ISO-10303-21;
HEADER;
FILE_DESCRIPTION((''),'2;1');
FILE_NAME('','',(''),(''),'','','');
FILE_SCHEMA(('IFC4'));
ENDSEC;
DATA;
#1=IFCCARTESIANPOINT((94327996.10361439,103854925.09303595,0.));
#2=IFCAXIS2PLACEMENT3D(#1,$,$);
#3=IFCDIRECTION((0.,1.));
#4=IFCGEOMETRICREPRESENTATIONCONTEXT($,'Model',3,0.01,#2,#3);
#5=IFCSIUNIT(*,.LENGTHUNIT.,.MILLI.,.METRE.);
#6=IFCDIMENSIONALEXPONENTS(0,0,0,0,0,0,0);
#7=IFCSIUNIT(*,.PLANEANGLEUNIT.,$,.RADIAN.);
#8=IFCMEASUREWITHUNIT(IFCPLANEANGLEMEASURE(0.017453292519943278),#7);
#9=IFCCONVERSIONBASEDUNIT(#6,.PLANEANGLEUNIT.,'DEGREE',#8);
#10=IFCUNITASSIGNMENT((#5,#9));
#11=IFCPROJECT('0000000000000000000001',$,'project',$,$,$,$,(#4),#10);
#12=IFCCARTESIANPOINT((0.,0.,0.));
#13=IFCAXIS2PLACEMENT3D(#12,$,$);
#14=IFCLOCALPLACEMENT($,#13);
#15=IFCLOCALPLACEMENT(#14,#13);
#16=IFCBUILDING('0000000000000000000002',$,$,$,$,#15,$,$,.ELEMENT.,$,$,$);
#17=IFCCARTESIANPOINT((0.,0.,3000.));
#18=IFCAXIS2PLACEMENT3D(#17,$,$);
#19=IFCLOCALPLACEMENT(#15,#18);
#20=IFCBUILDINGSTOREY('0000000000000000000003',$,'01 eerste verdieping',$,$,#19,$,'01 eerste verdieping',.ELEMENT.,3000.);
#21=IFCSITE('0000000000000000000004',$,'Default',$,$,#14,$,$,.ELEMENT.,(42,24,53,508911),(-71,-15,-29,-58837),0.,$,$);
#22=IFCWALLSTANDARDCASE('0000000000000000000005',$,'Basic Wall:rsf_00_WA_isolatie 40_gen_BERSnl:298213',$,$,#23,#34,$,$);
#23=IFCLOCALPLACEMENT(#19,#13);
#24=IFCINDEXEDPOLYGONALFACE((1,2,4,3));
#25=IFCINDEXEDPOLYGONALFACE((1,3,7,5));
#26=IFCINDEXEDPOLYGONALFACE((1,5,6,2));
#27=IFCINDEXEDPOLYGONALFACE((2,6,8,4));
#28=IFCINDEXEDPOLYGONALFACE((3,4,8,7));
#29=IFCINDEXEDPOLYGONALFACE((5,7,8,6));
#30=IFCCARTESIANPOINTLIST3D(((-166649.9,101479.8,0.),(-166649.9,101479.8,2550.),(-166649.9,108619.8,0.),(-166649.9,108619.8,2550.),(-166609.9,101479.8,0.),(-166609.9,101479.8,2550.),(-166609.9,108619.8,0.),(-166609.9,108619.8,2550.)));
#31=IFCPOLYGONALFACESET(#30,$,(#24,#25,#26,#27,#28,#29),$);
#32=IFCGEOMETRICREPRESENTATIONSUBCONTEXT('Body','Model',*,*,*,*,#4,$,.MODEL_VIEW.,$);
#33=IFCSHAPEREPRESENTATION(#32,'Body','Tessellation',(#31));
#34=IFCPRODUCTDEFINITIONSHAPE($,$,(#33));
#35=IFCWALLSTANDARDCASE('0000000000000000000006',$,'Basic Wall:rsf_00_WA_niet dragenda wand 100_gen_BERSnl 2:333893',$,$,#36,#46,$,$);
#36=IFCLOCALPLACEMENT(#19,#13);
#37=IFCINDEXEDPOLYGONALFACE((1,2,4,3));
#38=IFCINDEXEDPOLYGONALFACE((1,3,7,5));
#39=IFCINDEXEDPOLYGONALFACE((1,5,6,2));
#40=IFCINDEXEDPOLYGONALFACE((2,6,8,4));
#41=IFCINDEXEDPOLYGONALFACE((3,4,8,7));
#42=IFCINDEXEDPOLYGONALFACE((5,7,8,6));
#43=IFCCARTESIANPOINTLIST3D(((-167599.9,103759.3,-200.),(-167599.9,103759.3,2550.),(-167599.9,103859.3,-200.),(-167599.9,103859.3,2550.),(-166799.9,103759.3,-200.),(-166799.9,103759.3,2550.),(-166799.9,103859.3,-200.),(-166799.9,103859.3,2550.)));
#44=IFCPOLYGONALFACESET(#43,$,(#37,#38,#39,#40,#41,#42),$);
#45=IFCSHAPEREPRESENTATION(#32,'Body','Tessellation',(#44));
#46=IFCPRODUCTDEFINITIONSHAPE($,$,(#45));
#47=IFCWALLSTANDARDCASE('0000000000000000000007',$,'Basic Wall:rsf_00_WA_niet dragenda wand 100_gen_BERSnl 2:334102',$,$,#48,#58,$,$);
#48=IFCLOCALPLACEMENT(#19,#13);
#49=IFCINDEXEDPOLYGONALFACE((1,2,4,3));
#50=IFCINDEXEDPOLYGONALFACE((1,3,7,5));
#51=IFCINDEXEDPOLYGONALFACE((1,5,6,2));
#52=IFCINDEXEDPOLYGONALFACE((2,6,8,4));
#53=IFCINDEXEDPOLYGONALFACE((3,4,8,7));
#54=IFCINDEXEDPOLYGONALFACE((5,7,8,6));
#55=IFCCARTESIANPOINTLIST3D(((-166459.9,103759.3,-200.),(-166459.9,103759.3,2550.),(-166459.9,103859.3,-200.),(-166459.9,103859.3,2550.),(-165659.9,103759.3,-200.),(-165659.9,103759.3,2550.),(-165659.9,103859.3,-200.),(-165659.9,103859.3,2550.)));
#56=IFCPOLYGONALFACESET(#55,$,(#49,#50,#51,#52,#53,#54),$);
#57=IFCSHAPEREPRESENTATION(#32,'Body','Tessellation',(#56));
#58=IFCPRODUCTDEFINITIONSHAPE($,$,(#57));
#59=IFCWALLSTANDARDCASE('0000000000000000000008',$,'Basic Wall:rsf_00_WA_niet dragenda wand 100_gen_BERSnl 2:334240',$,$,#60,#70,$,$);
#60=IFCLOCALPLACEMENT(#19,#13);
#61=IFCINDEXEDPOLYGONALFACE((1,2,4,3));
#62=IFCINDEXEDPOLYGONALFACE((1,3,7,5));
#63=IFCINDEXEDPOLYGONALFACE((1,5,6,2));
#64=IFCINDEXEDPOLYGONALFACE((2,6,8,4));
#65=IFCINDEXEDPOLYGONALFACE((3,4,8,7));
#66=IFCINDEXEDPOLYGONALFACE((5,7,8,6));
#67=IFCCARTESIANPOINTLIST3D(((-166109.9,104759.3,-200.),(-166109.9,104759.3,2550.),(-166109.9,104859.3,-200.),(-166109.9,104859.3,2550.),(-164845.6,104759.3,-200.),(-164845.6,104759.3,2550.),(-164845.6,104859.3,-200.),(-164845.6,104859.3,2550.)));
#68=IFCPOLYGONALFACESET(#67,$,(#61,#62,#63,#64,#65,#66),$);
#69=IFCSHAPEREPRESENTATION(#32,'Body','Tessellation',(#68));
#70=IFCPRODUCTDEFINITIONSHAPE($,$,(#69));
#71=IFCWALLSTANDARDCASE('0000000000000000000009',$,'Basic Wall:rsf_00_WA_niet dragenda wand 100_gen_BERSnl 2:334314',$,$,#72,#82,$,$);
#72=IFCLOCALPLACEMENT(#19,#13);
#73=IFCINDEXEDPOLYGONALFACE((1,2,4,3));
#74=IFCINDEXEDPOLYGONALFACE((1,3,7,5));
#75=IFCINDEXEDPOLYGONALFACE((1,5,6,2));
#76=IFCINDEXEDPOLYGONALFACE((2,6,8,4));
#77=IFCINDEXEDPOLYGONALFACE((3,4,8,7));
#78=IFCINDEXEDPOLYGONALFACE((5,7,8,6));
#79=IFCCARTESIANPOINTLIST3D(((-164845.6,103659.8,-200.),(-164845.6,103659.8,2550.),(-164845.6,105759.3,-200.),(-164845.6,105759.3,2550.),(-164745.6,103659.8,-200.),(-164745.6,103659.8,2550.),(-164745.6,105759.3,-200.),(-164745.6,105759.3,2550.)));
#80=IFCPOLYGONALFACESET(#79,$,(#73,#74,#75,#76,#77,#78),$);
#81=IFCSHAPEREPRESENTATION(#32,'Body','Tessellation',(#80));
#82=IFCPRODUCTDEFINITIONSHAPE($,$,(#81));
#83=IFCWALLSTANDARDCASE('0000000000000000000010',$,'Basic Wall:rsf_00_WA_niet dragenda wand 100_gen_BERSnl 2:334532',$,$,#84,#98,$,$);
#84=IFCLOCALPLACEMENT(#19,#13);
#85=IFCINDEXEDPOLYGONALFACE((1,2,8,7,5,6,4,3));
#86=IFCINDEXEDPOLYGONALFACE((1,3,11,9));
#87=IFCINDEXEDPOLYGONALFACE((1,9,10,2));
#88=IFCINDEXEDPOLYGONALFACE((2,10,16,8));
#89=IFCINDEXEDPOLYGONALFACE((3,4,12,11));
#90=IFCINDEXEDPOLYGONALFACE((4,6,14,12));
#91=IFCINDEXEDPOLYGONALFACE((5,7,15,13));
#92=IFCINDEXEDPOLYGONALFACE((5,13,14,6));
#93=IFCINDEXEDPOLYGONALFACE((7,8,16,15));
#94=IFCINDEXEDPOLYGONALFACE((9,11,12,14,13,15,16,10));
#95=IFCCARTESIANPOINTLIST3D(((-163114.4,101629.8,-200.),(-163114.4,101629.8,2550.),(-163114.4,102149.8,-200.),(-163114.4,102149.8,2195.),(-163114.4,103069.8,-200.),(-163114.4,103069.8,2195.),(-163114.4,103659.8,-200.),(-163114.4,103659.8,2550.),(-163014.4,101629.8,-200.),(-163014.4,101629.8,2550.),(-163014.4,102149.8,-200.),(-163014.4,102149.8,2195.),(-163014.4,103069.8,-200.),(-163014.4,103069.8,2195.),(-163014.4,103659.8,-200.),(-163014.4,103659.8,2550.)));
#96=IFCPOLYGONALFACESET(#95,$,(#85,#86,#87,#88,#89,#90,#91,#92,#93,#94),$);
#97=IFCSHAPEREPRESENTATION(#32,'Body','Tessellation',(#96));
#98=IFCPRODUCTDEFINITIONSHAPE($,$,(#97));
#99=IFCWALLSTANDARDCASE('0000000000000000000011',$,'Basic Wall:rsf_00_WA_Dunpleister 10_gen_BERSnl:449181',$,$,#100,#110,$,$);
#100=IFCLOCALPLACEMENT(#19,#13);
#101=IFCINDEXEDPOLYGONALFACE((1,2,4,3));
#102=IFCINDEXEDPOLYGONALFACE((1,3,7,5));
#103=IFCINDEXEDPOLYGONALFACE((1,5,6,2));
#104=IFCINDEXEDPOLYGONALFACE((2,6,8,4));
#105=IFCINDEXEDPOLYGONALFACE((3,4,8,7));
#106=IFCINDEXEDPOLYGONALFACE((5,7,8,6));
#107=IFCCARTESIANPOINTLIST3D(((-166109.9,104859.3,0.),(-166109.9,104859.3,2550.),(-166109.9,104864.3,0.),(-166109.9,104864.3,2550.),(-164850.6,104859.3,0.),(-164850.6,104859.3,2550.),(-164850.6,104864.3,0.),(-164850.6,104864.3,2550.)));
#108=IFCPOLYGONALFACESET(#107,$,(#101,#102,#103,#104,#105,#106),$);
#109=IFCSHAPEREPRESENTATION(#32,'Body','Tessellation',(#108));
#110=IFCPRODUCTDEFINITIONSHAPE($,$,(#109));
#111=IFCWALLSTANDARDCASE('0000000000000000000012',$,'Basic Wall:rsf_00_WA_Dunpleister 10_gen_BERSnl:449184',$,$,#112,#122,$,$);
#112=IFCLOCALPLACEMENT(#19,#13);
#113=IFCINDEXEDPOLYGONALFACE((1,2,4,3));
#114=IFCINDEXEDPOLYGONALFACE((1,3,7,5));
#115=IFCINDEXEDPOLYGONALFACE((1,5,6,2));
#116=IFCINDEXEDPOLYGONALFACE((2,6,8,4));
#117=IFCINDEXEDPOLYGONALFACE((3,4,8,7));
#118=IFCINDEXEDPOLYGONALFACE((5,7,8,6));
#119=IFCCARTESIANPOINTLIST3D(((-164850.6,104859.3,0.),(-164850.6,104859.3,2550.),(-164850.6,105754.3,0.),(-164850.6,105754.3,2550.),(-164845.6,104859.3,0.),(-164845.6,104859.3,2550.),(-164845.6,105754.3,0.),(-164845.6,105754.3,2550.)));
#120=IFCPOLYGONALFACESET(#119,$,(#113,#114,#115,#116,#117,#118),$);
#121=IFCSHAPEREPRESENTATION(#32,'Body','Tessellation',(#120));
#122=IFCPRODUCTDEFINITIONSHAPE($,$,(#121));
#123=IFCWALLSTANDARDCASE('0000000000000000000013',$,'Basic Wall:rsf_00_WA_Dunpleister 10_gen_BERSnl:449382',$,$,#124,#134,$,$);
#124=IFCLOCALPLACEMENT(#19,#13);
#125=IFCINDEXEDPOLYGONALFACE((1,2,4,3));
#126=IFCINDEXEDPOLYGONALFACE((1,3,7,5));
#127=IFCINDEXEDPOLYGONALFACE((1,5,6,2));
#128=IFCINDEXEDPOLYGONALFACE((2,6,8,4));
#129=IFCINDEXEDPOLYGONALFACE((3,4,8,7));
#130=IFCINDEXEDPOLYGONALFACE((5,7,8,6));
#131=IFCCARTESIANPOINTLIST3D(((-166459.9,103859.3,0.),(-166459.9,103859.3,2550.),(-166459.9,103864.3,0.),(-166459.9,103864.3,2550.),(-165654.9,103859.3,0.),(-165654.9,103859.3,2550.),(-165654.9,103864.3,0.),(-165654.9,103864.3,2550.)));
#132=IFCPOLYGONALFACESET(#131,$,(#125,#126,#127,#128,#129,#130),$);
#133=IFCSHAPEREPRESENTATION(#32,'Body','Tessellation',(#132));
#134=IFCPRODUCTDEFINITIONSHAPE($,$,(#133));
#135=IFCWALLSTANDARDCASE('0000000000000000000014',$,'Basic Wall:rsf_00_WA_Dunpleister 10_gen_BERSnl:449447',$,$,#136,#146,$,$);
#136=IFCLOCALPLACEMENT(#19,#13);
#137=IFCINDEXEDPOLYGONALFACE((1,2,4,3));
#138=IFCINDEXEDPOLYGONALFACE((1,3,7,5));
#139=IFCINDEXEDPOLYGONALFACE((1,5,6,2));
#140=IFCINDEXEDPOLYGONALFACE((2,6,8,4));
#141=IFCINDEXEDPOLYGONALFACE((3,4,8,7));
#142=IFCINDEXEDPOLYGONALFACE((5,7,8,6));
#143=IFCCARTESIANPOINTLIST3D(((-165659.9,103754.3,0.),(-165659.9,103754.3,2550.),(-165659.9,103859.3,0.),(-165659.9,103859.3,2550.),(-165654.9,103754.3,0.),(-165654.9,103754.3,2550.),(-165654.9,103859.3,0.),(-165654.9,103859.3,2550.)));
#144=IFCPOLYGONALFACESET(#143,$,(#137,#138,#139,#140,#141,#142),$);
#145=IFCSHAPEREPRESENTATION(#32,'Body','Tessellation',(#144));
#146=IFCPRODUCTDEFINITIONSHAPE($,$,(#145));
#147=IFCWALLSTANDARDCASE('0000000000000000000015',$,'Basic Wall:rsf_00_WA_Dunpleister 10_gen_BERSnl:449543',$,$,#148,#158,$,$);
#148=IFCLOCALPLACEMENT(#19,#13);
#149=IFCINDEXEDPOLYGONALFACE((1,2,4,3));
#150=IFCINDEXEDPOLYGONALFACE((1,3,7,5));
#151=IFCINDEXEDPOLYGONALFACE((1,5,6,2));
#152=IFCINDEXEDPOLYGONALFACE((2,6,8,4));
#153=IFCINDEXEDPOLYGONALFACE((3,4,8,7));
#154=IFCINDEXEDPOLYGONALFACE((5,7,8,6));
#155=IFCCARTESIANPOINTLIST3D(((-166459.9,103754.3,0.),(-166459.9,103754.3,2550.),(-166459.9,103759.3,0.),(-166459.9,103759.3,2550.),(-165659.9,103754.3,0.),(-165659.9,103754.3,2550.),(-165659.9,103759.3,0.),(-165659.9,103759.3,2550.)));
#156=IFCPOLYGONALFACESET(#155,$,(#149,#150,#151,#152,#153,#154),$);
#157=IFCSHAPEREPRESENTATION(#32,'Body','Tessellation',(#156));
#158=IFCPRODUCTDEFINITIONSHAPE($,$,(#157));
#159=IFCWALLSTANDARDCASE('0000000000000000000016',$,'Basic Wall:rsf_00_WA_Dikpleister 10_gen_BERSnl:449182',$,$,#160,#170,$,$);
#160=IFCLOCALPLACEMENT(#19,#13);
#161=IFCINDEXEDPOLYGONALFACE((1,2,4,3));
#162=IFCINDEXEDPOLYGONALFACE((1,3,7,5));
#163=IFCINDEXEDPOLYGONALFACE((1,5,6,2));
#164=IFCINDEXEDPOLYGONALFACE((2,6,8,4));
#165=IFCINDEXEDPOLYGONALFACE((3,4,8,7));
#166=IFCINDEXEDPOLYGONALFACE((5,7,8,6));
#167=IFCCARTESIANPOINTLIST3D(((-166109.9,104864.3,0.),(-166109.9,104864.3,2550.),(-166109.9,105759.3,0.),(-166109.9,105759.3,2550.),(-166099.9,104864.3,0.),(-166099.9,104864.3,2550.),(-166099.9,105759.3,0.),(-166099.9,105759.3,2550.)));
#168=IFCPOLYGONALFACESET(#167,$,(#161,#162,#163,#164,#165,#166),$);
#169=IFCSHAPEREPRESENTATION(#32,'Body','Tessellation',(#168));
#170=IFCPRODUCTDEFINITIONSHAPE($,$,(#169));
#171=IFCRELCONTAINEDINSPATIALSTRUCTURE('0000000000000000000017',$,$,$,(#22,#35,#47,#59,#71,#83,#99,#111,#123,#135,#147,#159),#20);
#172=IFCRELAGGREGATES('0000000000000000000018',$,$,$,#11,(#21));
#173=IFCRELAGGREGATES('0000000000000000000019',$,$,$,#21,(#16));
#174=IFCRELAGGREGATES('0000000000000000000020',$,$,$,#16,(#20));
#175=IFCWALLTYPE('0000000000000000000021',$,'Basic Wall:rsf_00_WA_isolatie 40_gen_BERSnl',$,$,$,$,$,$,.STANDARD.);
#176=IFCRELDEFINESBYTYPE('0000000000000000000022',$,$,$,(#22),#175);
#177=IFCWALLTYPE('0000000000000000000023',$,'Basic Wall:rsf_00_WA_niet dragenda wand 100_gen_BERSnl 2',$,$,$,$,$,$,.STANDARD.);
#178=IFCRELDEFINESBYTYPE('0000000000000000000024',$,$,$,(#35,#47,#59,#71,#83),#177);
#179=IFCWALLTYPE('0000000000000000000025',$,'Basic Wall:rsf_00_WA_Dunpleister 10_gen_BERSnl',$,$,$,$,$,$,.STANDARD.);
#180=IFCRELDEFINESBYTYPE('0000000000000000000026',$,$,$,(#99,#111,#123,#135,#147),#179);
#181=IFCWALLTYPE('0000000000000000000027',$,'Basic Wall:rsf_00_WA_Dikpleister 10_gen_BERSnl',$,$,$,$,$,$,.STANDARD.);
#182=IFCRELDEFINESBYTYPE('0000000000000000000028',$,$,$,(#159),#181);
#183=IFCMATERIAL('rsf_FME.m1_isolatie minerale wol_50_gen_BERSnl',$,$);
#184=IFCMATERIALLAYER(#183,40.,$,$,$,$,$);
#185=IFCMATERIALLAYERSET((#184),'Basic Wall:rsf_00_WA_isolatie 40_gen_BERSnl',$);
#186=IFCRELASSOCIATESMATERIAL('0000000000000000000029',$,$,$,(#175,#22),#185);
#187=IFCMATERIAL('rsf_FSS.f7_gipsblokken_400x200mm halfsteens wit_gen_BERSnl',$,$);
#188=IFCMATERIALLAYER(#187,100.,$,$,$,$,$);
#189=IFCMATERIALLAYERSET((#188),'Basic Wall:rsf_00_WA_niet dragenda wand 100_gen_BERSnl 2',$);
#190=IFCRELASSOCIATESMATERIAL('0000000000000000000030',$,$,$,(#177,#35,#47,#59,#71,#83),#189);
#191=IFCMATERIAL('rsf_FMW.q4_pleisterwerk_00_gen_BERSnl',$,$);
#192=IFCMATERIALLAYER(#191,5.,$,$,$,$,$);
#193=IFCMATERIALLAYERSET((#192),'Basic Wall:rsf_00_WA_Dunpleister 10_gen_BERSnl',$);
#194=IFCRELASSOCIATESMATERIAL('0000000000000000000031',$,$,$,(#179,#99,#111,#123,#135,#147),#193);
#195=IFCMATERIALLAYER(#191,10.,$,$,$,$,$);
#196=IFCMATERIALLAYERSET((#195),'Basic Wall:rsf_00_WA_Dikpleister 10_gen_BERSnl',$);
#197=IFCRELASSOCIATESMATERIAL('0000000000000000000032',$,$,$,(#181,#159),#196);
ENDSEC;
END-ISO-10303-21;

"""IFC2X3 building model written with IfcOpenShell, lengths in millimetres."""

from ifc_helpers import new_model, entity, si_unit, converted_unit, direction, frame, frame_2d, origin, place, context, subcontext, project, spatial, rectangle, extrude, material, layer, layer_set, layer_usage, type_object, element, save


model = new_model("IFC2X3")

# Units and contexts
model_context = context("Model", 3, precision=0.01, world=frame((94327996.10361439, 103854925.09303595, 0.0)), true_north=direction((0.0, 1.0)))
body_context = subcontext(model_context, "Body", "Model", "MODEL_VIEW")
ifc_project = project(units=[si_unit("LENGTHUNIT", "METRE", prefix="MILLI"), converted_unit("PLANEANGLEUNIT", "DEGREE", entity("IfcPlaneAngleMeasure", 0.017453292519943278), si_unit("PLANEANGLEUNIT", "RADIAN"), dimensions=[0, 0, 0, 0, 0, 0, 0])], contexts=[model_context])

# Site, building, storey
site_placement = place(None, origin())
site = spatial("IfcSite", under=ifc_project, at=site_placement, Name="Default", CompositionType="ELEMENT", RefLatitude=(42, 24, 53, 508911), RefLongitude=(-71, -15, -29, -58837), RefElevation=0.0)
building_placement = place(site_placement, origin())
building = spatial("IfcBuilding", under=site, at=building_placement, CompositionType="ELEMENT")
storey_placement = place(building_placement, frame((0.0, 0.0, 3000.0)))
storey = spatial("IfcBuildingStorey", under=building, at=storey_placement, Name="01 eerste verdieping", LongName="01 eerste verdieping", CompositionType="ELEMENT", Elevation=3000.0)

# Walls
ifc_material_1 = material(Name="rsf_FME.m1_isolatie minerale wol_50_gen_BERSnl")
ifc_layer_1 = layer(ifc_material_1, 40.0)
ifc_layer_set_1 = layer_set([ifc_layer_1], Name="Basic Wall:rsf_00_WA_isolatie 40_gen_BERSnl")
ifc_layer_usage_1 = layer_usage(ifc_layer_set_1, "AXIS2", "NEGATIVE", 20.0)
wall_type_1 = type_object("IfcWallType", Name="Basic Wall:rsf_00_WA_isolatie 40_gen_BERSnl", PredefinedType="STANDARD", material=ifc_layer_set_1)
wall_1_placement = place(storey_placement, frame((-166629.9, 101479.8, 0.0), z_axis=(0.0, 0.0, 1.0), x_axis=(0.0, 1.0, 0.0)))
element("IfcWallStandardCase", 1, at=wall_1_placement, inside=storey, type_object=wall_type_1, material=ifc_layer_usage_1, Name="Basic Wall:rsf_00_WA_isolatie 40_gen_BERSnl:298213", context=body_context, shape_type="SweptSolid", body=[
    extrude(rectangle(XDim=7140.1, YDim=40.0, at=frame_2d((3570.0, 0.0), x_axis=(-1.0, 0.0))), origin(), (0.0, 0.0, 1.0), 2550.0),
])
ifc_material_2 = material(Name="rsf_FSS.f7_gipsblokken_400x200mm halfsteens wit_gen_BERSnl")
ifc_layer_2 = layer(ifc_material_2, 100.0)
ifc_layer_set_2 = layer_set([ifc_layer_2], Name="Basic Wall:rsf_00_WA_niet dragenda wand 100_gen_BERSnl 2")
ifc_layer_usage_2 = layer_usage(ifc_layer_set_2, "AXIS2", "NEGATIVE", 50.0)
wall_type_2 = type_object("IfcWallType", Name="Basic Wall:rsf_00_WA_niet dragenda wand 100_gen_BERSnl 2", PredefinedType="STANDARD", material=ifc_layer_set_2)
wall_2_placement = place(storey_placement, frame((-166799.9, 103809.3, -200.0), z_axis=(0.0, 0.0, 1.0), x_axis=(-1.0, 0.0, 0.0)))
element("IfcWallStandardCase", 2, at=wall_2_placement, inside=storey, type_object=wall_type_2, material=ifc_layer_usage_2, Name="Basic Wall:rsf_00_WA_niet dragenda wand 100_gen_BERSnl 2:333893", context=body_context, shape_type="SweptSolid", body=[
    extrude(rectangle(XDim=800.0, YDim=100.0, at=frame_2d((400.0, 0.0), x_axis=(-1.0, 0.0))), origin(), (0.0, 0.0, 1.0), 2750.0),
])
ifc_layer_usage_3 = layer_usage(ifc_layer_set_2, "AXIS2", "POSITIVE", -50.0)
wall_3_placement = place(storey_placement, frame((-165659.9, 103809.3, -200.0), z_axis=(0.0, 0.0, 1.0), x_axis=(-1.0, 0.0, 0.0)))
element("IfcWallStandardCase", 3, at=wall_3_placement, inside=storey, type_object=wall_type_2, material=ifc_layer_usage_3, Name="Basic Wall:rsf_00_WA_niet dragenda wand 100_gen_BERSnl 2:334102", context=body_context, shape_type="SweptSolid", body=[
    extrude(rectangle(XDim=800.0, YDim=100.0, at=frame_2d((400.0, 0.0), x_axis=(-1.0, 0.0))), origin(), (0.0, 0.0, 1.0), 2750.0),
])
ifc_layer_usage_4 = layer_usage(ifc_layer_set_2, "AXIS2", "NEGATIVE", 50.0)
wall_4_placement = place(storey_placement, frame((-166109.9, 104809.3, -200.0)))
element("IfcWallStandardCase", 4, at=wall_4_placement, inside=storey, type_object=wall_type_2, material=ifc_layer_usage_4, Name="Basic Wall:rsf_00_WA_niet dragenda wand 100_gen_BERSnl 2:334240", context=body_context, shape_type="SweptSolid", body=[
    extrude(rectangle(XDim=1264.3, YDim=100.0, at=frame_2d((632.1, 0.0), x_axis=(-1.0, 0.0))), origin(), (0.0, 0.0, 1.0), 2750.0),
])
ifc_layer_usage_5 = layer_usage(ifc_layer_set_2, "AXIS2", "NEGATIVE", 50.0)
wall_5_placement = place(storey_placement, frame((-164795.6, 105759.3, -200.0), z_axis=(0.0, 0.0, 1.0), x_axis=(0.0, -1.0, 0.0)))
element("IfcWallStandardCase", 5, at=wall_5_placement, inside=storey, type_object=wall_type_2, material=ifc_layer_usage_5, Name="Basic Wall:rsf_00_WA_niet dragenda wand 100_gen_BERSnl 2:334314", context=body_context, shape_type="SweptSolid", body=[
    extrude(rectangle(XDim=2099.5, YDim=100.0, at=frame_2d((1049.8, 0.0), x_axis=(-1.0, 0.0))), origin(), (0.0, 0.0, 1.0), 2750.0),
])

# Wall, opening
ifc_layer_usage_6 = layer_usage(ifc_layer_set_2, "AXIS2", "NEGATIVE", 50.0)
wall_6_placement = place(storey_placement, frame((-163064.4, 101629.8, -200.0), z_axis=(0.0, 0.0, 1.0), x_axis=(0.0, 1.0, 0.0)))
wall_6 = element("IfcWallStandardCase", 6, at=wall_6_placement, inside=storey, type_object=wall_type_2, material=ifc_layer_usage_6, Name="Basic Wall:rsf_00_WA_niet dragenda wand 100_gen_BERSnl 2:334532", context=body_context, shape_type="SweptSolid", body=[
    extrude(rectangle(XDim=2030.0, YDim=100.0, at=frame_2d((1015.0, 0.0), x_axis=(1.0, 0.0))), origin(), (0.0, 0.0, 1.0), 2750.0),
])
opening_1_placement = place(wall_6_placement, frame((520.0, -50.0, 0.0)))
element("IfcOpeningElement", 7, at=opening_1_placement, cuts=wall_6, ObjectType="Opening", context=body_context, shape_type="SweptSolid", body=[
    extrude(rectangle(XDim=2395.0, YDim=920.0, at=frame_2d((1197.5, 460.0), x_axis=(-1.0, 0.0))), frame((0.0, 0.0, 0.0), z_axis=(0.0, 1.0, 0.0), x_axis=(0.0, 0.0, 1.0)), (0.0, 0.0, 1.0), 100.0),
])

# Wall
ifc_material_3 = material(Name="rsf_FMW.q4_pleisterwerk_00_gen_BERSnl")
ifc_layer_3 = layer(ifc_material_3, 5.0)
ifc_layer_set_3 = layer_set([ifc_layer_3], Name="Basic Wall:rsf_00_WA_Dunpleister 10_gen_BERSnl")
ifc_layer_usage_7 = layer_usage(ifc_layer_set_3, "AXIS2", "POSITIVE", -2.5)
wall_type_3 = type_object("IfcWallType", Name="Basic Wall:rsf_00_WA_Dunpleister 10_gen_BERSnl", PredefinedType="STANDARD", material=ifc_layer_set_3)
wall_7_placement = place(storey_placement, frame((-166109.9, 104861.8, 0.0)))
element("IfcWallStandardCase", 8, at=wall_7_placement, inside=storey, type_object=wall_type_3, material=ifc_layer_usage_7, Name="Basic Wall:rsf_00_WA_Dunpleister 10_gen_BERSnl:449181", context=body_context, shape_type="SweptSolid", body=[
    extrude(rectangle(XDim=1259.3, YDim=5.0, at=frame_2d((629.6, 0.0), x_axis=(-1.0, 0.0))), origin(), (0.0, 0.0, 1.0), 2550.0),
])

# Walls
ifc_layer_usage_8 = layer_usage(ifc_layer_set_3, "AXIS2", "POSITIVE", -2.5)
wall_8_placement = place(storey_placement, frame((-164848.1, 104859.3, 0.0), z_axis=(0.0, 0.0, 1.0), x_axis=(0.0, 1.0, 0.0)))
element("IfcWallStandardCase", 9, at=wall_8_placement, inside=storey, type_object=wall_type_3, material=ifc_layer_usage_8, Name="Basic Wall:rsf_00_WA_Dunpleister 10_gen_BERSnl:449184", context=body_context, shape_type="SweptSolid", body=[
    extrude(rectangle(XDim=895.0, YDim=5.0, at=frame_2d((447.5, 0.0), x_axis=(-1.0, 0.0))), origin(), (0.0, 0.0, 1.0), 2550.0),
])
ifc_layer_usage_9 = layer_usage(ifc_layer_set_3, "AXIS2", "NEGATIVE", 2.5)
wall_9_placement = place(storey_placement, frame((-166459.9, 103861.8, 0.0)))
element("IfcWallStandardCase", 10, at=wall_9_placement, inside=storey, type_object=wall_type_3, material=ifc_layer_usage_9, Name="Basic Wall:rsf_00_WA_Dunpleister 10_gen_BERSnl:449382", context=body_context, shape_type="SweptSolid", body=[
    extrude(rectangle(XDim=805.0, YDim=5.0, at=frame_2d((402.5, 0.0), x_axis=(-1.0, 0.0))), origin(), (0.0, 0.0, 1.0), 2550.0),
])
ifc_layer_usage_10 = layer_usage(ifc_layer_set_3, "AXIS2", "NEGATIVE", 2.5)
wall_10_placement = place(storey_placement, frame((-165657.4, 103859.3, 0.0), z_axis=(0.0, 0.0, 1.0), x_axis=(0.0, -1.0, 0.0)))
element("IfcWallStandardCase", 11, at=wall_10_placement, inside=storey, type_object=wall_type_3, material=ifc_layer_usage_10, Name="Basic Wall:rsf_00_WA_Dunpleister 10_gen_BERSnl:449447", context=body_context, shape_type="SweptSolid", body=[
    extrude(rectangle(XDim=105.0, YDim=5.0, at=frame_2d((52.5, 0.0), x_axis=(-1.0, 0.0))), origin(), (0.0, 0.0, 1.0), 2550.0),
])
ifc_layer_usage_11 = layer_usage(ifc_layer_set_3, "AXIS2", "NEGATIVE", 2.5)
wall_11_placement = place(storey_placement, frame((-165659.9, 103756.8, 0.0), z_axis=(0.0, 0.0, 1.0), x_axis=(-1.0, 0.0, 0.0)))
element("IfcWallStandardCase", 12, at=wall_11_placement, inside=storey, type_object=wall_type_3, material=ifc_layer_usage_11, Name="Basic Wall:rsf_00_WA_Dunpleister 10_gen_BERSnl:449543", context=body_context, shape_type="SweptSolid", body=[
    extrude(rectangle(XDim=800.0, YDim=5.0, at=frame_2d((400.0, 0.0), x_axis=(-1.0, 0.0))), origin(), (0.0, 0.0, 1.0), 2550.0),
])

# Wall
ifc_layer_4 = layer(ifc_material_3, 10.0)
ifc_layer_set_4 = layer_set([ifc_layer_4], Name="Basic Wall:rsf_00_WA_Dikpleister 10_gen_BERSnl")
ifc_layer_usage_12 = layer_usage(ifc_layer_set_4, "AXIS2", "POSITIVE", -5.0)
wall_type_4 = type_object("IfcWallType", Name="Basic Wall:rsf_00_WA_Dikpleister 10_gen_BERSnl", PredefinedType="STANDARD", material=ifc_layer_set_4)
wall_12_placement = place(storey_placement, frame((-166104.9, 105759.3, 0.0), z_axis=(0.0, 0.0, 1.0), x_axis=(0.0, -1.0, 0.0)))
element("IfcWallStandardCase", 13, at=wall_12_placement, inside=storey, type_object=wall_type_4, material=ifc_layer_usage_12, Name="Basic Wall:rsf_00_WA_Dikpleister 10_gen_BERSnl:449182", context=body_context, shape_type="SweptSolid", body=[
    extrude(rectangle(XDim=895.0, YDim=10.0, at=frame_2d((447.5, 0.0), x_axis=(-1.0, 0.0))), origin(), (0.0, 0.0, 1.0), 2550.0),
])

save(model, "model.ifc")
